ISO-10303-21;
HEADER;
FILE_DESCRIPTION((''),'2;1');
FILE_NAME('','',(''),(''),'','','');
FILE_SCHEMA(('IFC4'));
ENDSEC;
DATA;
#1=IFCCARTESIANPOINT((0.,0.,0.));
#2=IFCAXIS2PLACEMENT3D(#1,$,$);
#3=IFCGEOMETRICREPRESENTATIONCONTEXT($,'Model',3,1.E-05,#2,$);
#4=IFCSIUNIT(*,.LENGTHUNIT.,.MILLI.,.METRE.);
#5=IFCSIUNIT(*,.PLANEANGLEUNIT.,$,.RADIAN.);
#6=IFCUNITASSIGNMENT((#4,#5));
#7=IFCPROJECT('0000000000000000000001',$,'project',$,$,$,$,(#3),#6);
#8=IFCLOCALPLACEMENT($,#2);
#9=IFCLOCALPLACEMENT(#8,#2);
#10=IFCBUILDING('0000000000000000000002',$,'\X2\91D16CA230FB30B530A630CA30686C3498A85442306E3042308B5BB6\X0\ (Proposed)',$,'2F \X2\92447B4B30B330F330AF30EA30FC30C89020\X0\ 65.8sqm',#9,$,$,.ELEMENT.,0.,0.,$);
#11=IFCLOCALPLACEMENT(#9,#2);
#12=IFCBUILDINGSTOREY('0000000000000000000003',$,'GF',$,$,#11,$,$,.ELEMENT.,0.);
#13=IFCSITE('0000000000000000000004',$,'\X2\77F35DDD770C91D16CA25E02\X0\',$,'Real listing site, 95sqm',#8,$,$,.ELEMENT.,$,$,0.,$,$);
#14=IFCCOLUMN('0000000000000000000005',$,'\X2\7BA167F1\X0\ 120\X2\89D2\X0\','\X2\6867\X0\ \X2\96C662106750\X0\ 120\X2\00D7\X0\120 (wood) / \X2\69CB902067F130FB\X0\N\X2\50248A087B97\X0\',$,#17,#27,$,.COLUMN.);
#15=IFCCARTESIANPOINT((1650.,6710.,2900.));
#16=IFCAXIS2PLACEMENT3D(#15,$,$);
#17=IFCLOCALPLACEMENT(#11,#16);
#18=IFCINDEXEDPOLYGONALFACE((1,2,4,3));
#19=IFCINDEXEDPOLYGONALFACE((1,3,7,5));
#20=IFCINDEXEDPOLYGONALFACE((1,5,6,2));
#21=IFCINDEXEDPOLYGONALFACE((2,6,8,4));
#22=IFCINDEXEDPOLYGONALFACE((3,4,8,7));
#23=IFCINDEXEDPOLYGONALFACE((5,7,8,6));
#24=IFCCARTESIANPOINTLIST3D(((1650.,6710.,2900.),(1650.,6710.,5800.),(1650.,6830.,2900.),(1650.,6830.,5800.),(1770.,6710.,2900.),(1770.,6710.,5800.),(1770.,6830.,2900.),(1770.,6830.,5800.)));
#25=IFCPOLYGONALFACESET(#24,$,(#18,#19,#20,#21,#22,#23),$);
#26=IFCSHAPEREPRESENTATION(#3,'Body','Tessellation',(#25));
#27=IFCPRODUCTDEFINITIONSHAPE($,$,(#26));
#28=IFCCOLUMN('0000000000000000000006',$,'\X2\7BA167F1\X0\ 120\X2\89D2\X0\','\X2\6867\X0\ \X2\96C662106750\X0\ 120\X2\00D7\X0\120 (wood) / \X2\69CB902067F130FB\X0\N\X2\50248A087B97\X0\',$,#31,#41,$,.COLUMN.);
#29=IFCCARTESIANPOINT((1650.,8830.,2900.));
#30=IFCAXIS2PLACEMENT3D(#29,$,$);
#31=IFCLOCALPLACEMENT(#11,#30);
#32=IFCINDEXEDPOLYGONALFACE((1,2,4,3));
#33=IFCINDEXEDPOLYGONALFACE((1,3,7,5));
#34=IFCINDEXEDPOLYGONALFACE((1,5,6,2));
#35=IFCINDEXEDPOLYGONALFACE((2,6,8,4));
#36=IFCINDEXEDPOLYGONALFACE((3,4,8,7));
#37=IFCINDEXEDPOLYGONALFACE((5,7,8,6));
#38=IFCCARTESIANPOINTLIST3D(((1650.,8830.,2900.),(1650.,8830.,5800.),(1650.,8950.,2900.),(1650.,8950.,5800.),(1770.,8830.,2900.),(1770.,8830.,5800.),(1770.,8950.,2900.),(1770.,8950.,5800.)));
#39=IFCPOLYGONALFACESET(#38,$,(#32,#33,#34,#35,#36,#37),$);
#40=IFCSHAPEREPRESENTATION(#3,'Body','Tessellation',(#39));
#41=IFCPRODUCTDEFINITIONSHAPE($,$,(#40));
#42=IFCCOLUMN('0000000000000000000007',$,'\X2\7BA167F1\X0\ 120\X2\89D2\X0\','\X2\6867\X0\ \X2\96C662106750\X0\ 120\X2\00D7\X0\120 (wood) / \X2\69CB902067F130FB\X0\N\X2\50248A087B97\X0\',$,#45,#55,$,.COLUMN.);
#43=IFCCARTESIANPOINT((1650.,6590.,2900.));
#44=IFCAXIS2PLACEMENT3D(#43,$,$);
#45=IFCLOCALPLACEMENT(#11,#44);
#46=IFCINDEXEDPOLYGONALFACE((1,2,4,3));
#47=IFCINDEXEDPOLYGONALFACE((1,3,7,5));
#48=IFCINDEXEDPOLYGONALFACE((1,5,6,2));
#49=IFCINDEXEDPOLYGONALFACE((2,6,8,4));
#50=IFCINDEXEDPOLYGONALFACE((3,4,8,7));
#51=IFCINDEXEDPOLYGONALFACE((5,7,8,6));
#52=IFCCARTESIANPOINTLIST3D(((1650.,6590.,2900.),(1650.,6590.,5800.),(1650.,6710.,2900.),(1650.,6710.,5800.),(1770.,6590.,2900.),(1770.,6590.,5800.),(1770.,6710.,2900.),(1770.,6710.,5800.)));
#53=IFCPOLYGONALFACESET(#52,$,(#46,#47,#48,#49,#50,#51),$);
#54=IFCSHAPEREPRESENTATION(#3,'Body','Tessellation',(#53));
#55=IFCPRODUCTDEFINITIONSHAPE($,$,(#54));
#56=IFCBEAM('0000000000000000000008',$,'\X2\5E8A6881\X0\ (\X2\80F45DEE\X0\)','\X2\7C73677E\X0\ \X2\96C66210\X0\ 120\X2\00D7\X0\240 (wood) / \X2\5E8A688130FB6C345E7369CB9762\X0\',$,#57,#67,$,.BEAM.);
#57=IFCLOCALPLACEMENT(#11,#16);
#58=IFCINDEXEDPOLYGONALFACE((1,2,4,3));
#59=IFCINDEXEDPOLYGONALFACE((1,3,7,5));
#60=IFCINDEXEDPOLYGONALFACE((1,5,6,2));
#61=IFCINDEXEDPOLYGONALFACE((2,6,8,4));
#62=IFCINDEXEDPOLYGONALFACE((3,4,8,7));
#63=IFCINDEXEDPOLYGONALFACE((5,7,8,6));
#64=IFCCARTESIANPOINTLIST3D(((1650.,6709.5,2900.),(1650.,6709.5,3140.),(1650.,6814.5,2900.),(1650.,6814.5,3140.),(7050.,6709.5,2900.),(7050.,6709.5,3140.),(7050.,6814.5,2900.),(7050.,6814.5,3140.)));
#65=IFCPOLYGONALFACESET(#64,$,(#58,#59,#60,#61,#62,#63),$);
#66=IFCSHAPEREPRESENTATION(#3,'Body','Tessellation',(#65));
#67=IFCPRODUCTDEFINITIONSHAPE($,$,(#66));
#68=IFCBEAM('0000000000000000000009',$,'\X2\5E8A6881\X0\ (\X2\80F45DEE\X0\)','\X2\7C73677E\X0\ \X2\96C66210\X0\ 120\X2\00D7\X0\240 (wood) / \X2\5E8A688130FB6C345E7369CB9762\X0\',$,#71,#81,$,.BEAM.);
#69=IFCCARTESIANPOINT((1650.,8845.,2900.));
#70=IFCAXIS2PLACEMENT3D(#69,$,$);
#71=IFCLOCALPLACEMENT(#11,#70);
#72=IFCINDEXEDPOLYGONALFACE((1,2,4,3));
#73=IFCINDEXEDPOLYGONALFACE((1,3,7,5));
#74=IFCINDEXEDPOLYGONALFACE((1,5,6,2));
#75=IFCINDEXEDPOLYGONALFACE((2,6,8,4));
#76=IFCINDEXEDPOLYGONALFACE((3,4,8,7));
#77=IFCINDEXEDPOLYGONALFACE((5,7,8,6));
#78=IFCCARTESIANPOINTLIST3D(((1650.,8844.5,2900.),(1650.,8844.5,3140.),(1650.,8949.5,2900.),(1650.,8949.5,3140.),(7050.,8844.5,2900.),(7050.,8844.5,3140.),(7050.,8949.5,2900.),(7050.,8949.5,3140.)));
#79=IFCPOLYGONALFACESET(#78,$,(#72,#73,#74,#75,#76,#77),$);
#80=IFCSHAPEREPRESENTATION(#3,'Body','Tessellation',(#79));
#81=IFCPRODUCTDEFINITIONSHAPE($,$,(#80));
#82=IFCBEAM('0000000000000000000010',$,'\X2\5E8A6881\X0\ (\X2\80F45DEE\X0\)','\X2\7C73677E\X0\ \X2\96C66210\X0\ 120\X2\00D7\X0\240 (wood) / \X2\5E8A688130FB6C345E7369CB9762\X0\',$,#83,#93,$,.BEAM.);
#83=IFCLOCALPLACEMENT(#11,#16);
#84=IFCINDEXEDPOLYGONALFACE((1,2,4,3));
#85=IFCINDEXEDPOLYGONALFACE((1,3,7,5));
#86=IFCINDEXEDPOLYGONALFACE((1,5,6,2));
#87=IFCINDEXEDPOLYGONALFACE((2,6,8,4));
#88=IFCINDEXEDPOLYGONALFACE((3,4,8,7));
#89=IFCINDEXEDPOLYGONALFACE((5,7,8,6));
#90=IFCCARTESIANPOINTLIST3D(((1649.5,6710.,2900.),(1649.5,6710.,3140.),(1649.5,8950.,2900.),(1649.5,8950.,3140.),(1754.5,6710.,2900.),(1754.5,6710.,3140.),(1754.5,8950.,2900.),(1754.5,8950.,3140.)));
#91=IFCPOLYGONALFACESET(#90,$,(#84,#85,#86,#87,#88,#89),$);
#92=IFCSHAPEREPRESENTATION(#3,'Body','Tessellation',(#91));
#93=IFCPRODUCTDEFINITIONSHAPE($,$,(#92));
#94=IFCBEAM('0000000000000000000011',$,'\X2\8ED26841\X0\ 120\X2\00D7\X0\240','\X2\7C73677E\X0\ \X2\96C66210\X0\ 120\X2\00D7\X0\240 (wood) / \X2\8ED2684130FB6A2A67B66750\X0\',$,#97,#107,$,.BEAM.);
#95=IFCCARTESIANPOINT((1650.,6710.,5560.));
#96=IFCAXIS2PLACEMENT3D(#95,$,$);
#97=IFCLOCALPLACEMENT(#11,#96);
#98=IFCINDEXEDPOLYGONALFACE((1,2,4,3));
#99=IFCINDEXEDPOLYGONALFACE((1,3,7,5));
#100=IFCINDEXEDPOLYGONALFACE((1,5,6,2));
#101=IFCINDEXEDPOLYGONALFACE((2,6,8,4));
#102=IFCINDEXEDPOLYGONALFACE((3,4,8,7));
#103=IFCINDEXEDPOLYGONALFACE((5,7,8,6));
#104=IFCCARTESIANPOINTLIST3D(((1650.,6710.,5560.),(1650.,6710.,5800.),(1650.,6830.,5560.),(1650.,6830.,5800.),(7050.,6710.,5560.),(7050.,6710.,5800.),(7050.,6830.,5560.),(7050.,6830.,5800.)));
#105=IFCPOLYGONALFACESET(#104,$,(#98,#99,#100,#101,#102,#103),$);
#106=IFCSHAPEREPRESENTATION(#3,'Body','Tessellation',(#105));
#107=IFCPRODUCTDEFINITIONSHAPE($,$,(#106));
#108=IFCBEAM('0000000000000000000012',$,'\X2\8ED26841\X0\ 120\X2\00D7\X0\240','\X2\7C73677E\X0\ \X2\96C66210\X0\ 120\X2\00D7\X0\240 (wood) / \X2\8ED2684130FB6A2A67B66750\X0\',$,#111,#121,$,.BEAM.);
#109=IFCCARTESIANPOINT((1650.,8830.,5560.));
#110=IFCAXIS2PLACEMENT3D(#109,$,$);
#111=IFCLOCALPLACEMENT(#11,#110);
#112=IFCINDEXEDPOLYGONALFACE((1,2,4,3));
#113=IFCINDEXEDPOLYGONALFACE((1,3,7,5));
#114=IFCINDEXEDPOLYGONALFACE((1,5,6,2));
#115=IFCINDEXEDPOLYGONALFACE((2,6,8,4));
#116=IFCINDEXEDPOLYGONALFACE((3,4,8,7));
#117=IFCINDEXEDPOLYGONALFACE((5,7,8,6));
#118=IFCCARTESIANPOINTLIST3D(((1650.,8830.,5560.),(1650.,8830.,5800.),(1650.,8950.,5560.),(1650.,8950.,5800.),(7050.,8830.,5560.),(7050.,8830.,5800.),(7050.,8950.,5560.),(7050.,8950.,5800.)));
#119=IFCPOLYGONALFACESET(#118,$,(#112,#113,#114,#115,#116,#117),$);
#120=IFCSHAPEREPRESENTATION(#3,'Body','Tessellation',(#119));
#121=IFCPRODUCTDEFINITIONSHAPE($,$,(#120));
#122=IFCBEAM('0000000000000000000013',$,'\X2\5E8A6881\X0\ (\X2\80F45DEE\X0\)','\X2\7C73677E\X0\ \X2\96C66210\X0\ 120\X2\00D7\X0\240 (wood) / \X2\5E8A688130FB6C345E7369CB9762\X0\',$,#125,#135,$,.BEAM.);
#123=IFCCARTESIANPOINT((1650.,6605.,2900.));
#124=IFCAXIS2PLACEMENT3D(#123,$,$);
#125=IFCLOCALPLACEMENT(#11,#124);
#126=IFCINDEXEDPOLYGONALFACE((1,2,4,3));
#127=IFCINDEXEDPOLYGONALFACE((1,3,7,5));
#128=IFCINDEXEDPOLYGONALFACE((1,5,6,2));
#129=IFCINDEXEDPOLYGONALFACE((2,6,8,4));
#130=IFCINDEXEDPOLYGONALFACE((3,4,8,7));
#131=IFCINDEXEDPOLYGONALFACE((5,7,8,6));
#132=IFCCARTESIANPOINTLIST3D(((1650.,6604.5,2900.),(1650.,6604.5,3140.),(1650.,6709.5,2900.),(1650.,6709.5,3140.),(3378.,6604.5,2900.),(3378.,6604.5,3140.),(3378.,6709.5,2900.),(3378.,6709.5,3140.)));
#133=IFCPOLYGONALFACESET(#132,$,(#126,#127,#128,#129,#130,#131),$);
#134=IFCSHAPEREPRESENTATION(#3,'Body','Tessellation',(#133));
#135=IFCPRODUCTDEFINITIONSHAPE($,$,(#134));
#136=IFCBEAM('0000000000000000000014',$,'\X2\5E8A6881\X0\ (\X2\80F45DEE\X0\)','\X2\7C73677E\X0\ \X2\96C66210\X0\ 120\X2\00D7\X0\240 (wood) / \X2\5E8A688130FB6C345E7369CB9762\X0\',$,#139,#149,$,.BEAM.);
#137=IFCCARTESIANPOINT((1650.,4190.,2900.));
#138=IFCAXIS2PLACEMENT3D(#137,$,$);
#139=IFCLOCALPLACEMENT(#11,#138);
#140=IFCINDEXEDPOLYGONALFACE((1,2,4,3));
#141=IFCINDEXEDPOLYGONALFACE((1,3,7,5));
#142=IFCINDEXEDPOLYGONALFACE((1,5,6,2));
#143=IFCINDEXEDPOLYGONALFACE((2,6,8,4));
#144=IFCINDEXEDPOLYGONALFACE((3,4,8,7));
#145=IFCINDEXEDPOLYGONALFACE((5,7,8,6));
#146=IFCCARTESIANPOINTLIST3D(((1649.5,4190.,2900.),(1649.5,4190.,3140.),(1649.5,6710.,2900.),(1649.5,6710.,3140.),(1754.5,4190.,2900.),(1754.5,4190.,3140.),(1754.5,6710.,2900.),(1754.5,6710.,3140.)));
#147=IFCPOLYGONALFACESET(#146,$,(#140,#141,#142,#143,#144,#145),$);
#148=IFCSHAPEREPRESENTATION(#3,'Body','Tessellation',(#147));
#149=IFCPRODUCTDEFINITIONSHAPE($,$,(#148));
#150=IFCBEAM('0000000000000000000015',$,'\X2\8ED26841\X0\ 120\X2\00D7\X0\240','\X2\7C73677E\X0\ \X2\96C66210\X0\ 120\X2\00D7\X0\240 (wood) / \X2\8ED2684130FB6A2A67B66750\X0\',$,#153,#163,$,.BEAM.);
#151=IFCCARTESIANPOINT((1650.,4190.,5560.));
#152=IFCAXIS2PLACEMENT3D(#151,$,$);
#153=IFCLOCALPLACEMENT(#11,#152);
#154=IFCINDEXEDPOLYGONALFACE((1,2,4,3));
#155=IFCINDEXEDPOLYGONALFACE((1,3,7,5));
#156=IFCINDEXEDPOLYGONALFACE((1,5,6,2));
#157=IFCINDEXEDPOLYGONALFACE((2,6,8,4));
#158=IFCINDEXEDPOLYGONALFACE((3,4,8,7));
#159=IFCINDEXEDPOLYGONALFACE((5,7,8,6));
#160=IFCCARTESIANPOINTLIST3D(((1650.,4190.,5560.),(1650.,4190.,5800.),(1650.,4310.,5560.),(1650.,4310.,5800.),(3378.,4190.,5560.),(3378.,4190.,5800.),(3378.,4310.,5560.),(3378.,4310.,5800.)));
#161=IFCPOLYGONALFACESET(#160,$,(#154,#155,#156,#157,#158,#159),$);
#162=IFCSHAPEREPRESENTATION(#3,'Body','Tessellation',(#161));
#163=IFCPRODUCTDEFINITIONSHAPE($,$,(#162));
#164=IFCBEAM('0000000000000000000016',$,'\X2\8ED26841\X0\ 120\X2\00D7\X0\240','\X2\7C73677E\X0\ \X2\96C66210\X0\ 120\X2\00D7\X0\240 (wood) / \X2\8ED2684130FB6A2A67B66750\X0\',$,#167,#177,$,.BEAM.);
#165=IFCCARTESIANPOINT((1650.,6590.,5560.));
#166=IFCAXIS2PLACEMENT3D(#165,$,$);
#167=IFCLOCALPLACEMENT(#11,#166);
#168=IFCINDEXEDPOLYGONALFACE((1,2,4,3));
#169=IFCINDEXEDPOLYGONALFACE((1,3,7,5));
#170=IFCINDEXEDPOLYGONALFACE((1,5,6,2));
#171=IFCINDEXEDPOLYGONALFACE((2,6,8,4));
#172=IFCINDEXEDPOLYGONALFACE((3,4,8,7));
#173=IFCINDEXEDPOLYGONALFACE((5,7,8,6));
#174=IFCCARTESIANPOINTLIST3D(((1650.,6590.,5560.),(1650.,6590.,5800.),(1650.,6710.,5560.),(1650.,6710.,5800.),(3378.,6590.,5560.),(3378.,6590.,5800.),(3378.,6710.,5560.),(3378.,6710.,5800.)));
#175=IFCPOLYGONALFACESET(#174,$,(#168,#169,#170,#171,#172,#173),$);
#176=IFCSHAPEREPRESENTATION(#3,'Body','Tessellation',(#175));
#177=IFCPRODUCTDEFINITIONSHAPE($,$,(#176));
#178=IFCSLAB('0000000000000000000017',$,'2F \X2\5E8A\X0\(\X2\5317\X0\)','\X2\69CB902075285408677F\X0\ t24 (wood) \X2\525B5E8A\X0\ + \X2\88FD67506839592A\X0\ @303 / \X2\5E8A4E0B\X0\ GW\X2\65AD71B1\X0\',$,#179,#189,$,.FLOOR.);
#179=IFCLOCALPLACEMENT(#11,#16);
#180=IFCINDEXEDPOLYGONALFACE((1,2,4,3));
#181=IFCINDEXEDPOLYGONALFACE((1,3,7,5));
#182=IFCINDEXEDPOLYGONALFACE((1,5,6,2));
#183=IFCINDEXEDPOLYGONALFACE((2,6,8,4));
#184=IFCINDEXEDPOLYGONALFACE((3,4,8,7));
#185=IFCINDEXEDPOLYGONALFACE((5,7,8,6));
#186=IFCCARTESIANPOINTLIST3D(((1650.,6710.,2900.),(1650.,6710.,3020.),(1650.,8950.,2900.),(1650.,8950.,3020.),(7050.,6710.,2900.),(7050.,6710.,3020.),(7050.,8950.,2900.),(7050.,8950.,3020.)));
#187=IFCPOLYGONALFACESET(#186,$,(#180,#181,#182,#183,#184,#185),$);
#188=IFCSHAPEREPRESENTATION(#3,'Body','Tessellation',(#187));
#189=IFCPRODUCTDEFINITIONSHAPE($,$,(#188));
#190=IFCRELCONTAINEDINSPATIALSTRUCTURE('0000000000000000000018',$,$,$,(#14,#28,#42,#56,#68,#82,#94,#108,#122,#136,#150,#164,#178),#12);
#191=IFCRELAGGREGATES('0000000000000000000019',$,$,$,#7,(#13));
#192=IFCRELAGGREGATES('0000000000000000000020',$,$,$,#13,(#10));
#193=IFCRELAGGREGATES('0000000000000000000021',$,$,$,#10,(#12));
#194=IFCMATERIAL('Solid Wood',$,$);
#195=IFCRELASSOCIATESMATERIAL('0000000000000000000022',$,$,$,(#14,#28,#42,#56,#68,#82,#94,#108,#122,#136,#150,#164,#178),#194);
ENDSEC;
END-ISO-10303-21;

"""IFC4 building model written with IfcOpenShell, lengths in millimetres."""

from ifc_helpers import new_model, si_unit, frame, frame_2d, origin, place, context, project, spatial, rectangle, extrude, material, element, save


model = new_model("IFC4")

# Units and contexts
model_context = context("Model", 3, precision=1e-05, world=origin())
ifc_project = project(units=[si_unit("LENGTHUNIT", "METRE", prefix="MILLI"), si_unit("PLANEANGLEUNIT", "RADIAN")], contexts=[model_context])

# Site, building, storey
site_placement = place(None, origin())
site = spatial("IfcSite", under=ifc_project, at=site_placement, Name="石川県金沢市", ObjectType="Real listing site, 95sqm", CompositionType="ELEMENT", RefElevation=0.0)
building_placement = place(site_placement, origin())
building = spatial("IfcBuilding", under=site, at=building_placement, Name="金沢・サウナと水風呂のある家 (Proposed)", ObjectType="2F 鉄筋コンクリート造 65.8sqm", CompositionType="ELEMENT", ElevationOfRefHeight=0.0, ElevationOfTerrain=0.0)
storey_placement = place(building_placement, origin())
storey = spatial("IfcBuildingStorey", under=building, at=storey_placement, Name="GF", CompositionType="ELEMENT", Elevation=0.0)

# Columns
ifc_material_1 = material(Name="Solid Wood")
column_1_placement = place(storey_placement, frame((1650.0, 6710.0, 2900.0)))
element("IfcColumn", 1, at=column_1_placement, inside=storey, material=ifc_material_1, Name="管柱 120角", Description="桧 集成材 120×120 (wood) / 構造柱・N値計算", PredefinedType="COLUMN", context=model_context, shape_type="SweptSolid", body=[
    extrude(rectangle(XDim=120.0, YDim=120.0, at=frame_2d((60.0, 60.0))), frame((1650.0, 6710.0, 2900.0)), (0.0, 0.0, 1.0), 2900.0),
])
column_2_placement = place(storey_placement, frame((1650.0, 8830.0, 2900.0)))
element("IfcColumn", 2, at=column_2_placement, inside=storey, material=ifc_material_1, Name="管柱 120角", Description="桧 集成材 120×120 (wood) / 構造柱・N値計算", PredefinedType="COLUMN", context=model_context, shape_type="SweptSolid", body=[
    extrude(rectangle(XDim=120.0, YDim=120.0, at=frame_2d((60.0, 60.0))), frame((1650.0, 8830.0, 2900.0)), (0.0, 0.0, 1.0), 2900.0),
])
column_3_placement = place(storey_placement, frame((1650.0, 6590.0, 2900.0)))
element("IfcColumn", 3, at=column_3_placement, inside=storey, material=ifc_material_1, Name="管柱 120角", Description="桧 集成材 120×120 (wood) / 構造柱・N値計算", PredefinedType="COLUMN", context=model_context, shape_type="SweptSolid", body=[
    extrude(rectangle(XDim=120.0, YDim=120.0, at=frame_2d((60.0, 60.0))), frame((1650.0, 6590.0, 2900.0)), (0.0, 0.0, 1.0), 2900.0),
])

# Beams
beam_1_placement = place(storey_placement, frame((1650.0, 6710.0, 2900.0)))
element("IfcBeam", 4, at=beam_1_placement, inside=storey, material=ifc_material_1, Name="床梁 (胴差)", Description="米松 集成 120×240 (wood) / 床梁・水平構面", PredefinedType="BEAM", context=model_context, shape_type="SweptSolid", body=[
    extrude(rectangle(XDim=5400.0, YDim=105.0, at=frame_2d((2700.0, 52.0))), frame((1650.0, 6710.0, 2900.0)), (0.0, 0.0, 1.0), 240.0),
])
beam_2_placement = place(storey_placement, frame((1650.0, 8845.0, 2900.0)))
element("IfcBeam", 5, at=beam_2_placement, inside=storey, material=ifc_material_1, Name="床梁 (胴差)", Description="米松 集成 120×240 (wood) / 床梁・水平構面", PredefinedType="BEAM", context=model_context, shape_type="SweptSolid", body=[
    extrude(rectangle(XDim=5400.0, YDim=105.0, at=frame_2d((2700.0, 52.0))), frame((1650.0, 8845.0, 2900.0)), (0.0, 0.0, 1.0), 240.0),
])
beam_3_placement = place(storey_placement, frame((1650.0, 6710.0, 2900.0)))
element("IfcBeam", 6, at=beam_3_placement, inside=storey, material=ifc_material_1, Name="床梁 (胴差)", Description="米松 集成 120×240 (wood) / 床梁・水平構面", PredefinedType="BEAM", context=model_context, shape_type="SweptSolid", body=[
    extrude(rectangle(XDim=105.0, YDim=2240.0, at=frame_2d((52.0, 1120.0))), frame((1650.0, 6710.0, 2900.0)), (0.0, 0.0, 1.0), 240.0),
])
beam_4_placement = place(storey_placement, frame((1650.0, 6710.0, 5560.0)))
element("IfcBeam", 7, at=beam_4_placement, inside=storey, material=ifc_material_1, Name="軒桁 120×240", Description="米松 集成 120×240 (wood) / 軒桁・横架材", PredefinedType="BEAM", context=model_context, shape_type="SweptSolid", body=[
    extrude(rectangle(XDim=5400.0, YDim=120.0, at=frame_2d((2700.0, 60.0))), frame((1650.0, 6710.0, 5560.0)), (0.0, 0.0, 1.0), 240.0),
])
beam_5_placement = place(storey_placement, frame((1650.0, 8830.0, 5560.0)))
element("IfcBeam", 8, at=beam_5_placement, inside=storey, material=ifc_material_1, Name="軒桁 120×240", Description="米松 集成 120×240 (wood) / 軒桁・横架材", PredefinedType="BEAM", context=model_context, shape_type="SweptSolid", body=[
    extrude(rectangle(XDim=5400.0, YDim=120.0, at=frame_2d((2700.0, 60.0))), frame((1650.0, 8830.0, 5560.0)), (0.0, 0.0, 1.0), 240.0),
])
beam_6_placement = place(storey_placement, frame((1650.0, 6605.0, 2900.0)))
element("IfcBeam", 9, at=beam_6_placement, inside=storey, material=ifc_material_1, Name="床梁 (胴差)", Description="米松 集成 120×240 (wood) / 床梁・水平構面", PredefinedType="BEAM", context=model_context, shape_type="SweptSolid", body=[
    extrude(rectangle(XDim=1728.0, YDim=105.0, at=frame_2d((864.0, 52.0))), frame((1650.0, 6605.0, 2900.0)), (0.0, 0.0, 1.0), 240.0),
])
beam_7_placement = place(storey_placement, frame((1650.0, 4190.0, 2900.0)))
element("IfcBeam", 10, at=beam_7_placement, inside=storey, material=ifc_material_1, Name="床梁 (胴差)", Description="米松 集成 120×240 (wood) / 床梁・水平構面", PredefinedType="BEAM", context=model_context, shape_type="SweptSolid", body=[
    extrude(rectangle(XDim=105.0, YDim=2520.0, at=frame_2d((52.0, 1260.0))), frame((1650.0, 4190.0, 2900.0)), (0.0, 0.0, 1.0), 240.0),
])
beam_8_placement = place(storey_placement, frame((1650.0, 4190.0, 5560.0)))
element("IfcBeam", 11, at=beam_8_placement, inside=storey, material=ifc_material_1, Name="軒桁 120×240", Description="米松 集成 120×240 (wood) / 軒桁・横架材", PredefinedType="BEAM", context=model_context, shape_type="SweptSolid", body=[
    extrude(rectangle(XDim=1728.0, YDim=120.0, at=frame_2d((864.0, 60.0))), frame((1650.0, 4190.0, 5560.0)), (0.0, 0.0, 1.0), 240.0),
])
beam_9_placement = place(storey_placement, frame((1650.0, 6590.0, 5560.0)))
element("IfcBeam", 12, at=beam_9_placement, inside=storey, material=ifc_material_1, Name="軒桁 120×240", Description="米松 集成 120×240 (wood) / 軒桁・横架材", PredefinedType="BEAM", context=model_context, shape_type="SweptSolid", body=[
    extrude(rectangle(XDim=1728.0, YDim=120.0, at=frame_2d((864.0, 60.0))), frame((1650.0, 6590.0, 5560.0)), (0.0, 0.0, 1.0), 240.0),
])

# Slab
slab_placement = place(storey_placement, frame((1650.0, 6710.0, 2900.0)))
element("IfcSlab", 13, at=slab_placement, inside=storey, material=ifc_material_1, Name="2F 床(北)", Description="構造用合板 t24 (wood) 剛床 + 製材根太 @303 / 床下 GW断熱", PredefinedType="FLOOR", context=model_context, shape_type="SweptSolid", body=[
    extrude(rectangle(XDim=5400.0, YDim=2240.0, at=frame_2d((2700.0, 1120.0))), frame((1650.0, 6710.0, 2900.0)), (0.0, 0.0, 1.0), 120.0),
])

save(model, "model.ifc")
